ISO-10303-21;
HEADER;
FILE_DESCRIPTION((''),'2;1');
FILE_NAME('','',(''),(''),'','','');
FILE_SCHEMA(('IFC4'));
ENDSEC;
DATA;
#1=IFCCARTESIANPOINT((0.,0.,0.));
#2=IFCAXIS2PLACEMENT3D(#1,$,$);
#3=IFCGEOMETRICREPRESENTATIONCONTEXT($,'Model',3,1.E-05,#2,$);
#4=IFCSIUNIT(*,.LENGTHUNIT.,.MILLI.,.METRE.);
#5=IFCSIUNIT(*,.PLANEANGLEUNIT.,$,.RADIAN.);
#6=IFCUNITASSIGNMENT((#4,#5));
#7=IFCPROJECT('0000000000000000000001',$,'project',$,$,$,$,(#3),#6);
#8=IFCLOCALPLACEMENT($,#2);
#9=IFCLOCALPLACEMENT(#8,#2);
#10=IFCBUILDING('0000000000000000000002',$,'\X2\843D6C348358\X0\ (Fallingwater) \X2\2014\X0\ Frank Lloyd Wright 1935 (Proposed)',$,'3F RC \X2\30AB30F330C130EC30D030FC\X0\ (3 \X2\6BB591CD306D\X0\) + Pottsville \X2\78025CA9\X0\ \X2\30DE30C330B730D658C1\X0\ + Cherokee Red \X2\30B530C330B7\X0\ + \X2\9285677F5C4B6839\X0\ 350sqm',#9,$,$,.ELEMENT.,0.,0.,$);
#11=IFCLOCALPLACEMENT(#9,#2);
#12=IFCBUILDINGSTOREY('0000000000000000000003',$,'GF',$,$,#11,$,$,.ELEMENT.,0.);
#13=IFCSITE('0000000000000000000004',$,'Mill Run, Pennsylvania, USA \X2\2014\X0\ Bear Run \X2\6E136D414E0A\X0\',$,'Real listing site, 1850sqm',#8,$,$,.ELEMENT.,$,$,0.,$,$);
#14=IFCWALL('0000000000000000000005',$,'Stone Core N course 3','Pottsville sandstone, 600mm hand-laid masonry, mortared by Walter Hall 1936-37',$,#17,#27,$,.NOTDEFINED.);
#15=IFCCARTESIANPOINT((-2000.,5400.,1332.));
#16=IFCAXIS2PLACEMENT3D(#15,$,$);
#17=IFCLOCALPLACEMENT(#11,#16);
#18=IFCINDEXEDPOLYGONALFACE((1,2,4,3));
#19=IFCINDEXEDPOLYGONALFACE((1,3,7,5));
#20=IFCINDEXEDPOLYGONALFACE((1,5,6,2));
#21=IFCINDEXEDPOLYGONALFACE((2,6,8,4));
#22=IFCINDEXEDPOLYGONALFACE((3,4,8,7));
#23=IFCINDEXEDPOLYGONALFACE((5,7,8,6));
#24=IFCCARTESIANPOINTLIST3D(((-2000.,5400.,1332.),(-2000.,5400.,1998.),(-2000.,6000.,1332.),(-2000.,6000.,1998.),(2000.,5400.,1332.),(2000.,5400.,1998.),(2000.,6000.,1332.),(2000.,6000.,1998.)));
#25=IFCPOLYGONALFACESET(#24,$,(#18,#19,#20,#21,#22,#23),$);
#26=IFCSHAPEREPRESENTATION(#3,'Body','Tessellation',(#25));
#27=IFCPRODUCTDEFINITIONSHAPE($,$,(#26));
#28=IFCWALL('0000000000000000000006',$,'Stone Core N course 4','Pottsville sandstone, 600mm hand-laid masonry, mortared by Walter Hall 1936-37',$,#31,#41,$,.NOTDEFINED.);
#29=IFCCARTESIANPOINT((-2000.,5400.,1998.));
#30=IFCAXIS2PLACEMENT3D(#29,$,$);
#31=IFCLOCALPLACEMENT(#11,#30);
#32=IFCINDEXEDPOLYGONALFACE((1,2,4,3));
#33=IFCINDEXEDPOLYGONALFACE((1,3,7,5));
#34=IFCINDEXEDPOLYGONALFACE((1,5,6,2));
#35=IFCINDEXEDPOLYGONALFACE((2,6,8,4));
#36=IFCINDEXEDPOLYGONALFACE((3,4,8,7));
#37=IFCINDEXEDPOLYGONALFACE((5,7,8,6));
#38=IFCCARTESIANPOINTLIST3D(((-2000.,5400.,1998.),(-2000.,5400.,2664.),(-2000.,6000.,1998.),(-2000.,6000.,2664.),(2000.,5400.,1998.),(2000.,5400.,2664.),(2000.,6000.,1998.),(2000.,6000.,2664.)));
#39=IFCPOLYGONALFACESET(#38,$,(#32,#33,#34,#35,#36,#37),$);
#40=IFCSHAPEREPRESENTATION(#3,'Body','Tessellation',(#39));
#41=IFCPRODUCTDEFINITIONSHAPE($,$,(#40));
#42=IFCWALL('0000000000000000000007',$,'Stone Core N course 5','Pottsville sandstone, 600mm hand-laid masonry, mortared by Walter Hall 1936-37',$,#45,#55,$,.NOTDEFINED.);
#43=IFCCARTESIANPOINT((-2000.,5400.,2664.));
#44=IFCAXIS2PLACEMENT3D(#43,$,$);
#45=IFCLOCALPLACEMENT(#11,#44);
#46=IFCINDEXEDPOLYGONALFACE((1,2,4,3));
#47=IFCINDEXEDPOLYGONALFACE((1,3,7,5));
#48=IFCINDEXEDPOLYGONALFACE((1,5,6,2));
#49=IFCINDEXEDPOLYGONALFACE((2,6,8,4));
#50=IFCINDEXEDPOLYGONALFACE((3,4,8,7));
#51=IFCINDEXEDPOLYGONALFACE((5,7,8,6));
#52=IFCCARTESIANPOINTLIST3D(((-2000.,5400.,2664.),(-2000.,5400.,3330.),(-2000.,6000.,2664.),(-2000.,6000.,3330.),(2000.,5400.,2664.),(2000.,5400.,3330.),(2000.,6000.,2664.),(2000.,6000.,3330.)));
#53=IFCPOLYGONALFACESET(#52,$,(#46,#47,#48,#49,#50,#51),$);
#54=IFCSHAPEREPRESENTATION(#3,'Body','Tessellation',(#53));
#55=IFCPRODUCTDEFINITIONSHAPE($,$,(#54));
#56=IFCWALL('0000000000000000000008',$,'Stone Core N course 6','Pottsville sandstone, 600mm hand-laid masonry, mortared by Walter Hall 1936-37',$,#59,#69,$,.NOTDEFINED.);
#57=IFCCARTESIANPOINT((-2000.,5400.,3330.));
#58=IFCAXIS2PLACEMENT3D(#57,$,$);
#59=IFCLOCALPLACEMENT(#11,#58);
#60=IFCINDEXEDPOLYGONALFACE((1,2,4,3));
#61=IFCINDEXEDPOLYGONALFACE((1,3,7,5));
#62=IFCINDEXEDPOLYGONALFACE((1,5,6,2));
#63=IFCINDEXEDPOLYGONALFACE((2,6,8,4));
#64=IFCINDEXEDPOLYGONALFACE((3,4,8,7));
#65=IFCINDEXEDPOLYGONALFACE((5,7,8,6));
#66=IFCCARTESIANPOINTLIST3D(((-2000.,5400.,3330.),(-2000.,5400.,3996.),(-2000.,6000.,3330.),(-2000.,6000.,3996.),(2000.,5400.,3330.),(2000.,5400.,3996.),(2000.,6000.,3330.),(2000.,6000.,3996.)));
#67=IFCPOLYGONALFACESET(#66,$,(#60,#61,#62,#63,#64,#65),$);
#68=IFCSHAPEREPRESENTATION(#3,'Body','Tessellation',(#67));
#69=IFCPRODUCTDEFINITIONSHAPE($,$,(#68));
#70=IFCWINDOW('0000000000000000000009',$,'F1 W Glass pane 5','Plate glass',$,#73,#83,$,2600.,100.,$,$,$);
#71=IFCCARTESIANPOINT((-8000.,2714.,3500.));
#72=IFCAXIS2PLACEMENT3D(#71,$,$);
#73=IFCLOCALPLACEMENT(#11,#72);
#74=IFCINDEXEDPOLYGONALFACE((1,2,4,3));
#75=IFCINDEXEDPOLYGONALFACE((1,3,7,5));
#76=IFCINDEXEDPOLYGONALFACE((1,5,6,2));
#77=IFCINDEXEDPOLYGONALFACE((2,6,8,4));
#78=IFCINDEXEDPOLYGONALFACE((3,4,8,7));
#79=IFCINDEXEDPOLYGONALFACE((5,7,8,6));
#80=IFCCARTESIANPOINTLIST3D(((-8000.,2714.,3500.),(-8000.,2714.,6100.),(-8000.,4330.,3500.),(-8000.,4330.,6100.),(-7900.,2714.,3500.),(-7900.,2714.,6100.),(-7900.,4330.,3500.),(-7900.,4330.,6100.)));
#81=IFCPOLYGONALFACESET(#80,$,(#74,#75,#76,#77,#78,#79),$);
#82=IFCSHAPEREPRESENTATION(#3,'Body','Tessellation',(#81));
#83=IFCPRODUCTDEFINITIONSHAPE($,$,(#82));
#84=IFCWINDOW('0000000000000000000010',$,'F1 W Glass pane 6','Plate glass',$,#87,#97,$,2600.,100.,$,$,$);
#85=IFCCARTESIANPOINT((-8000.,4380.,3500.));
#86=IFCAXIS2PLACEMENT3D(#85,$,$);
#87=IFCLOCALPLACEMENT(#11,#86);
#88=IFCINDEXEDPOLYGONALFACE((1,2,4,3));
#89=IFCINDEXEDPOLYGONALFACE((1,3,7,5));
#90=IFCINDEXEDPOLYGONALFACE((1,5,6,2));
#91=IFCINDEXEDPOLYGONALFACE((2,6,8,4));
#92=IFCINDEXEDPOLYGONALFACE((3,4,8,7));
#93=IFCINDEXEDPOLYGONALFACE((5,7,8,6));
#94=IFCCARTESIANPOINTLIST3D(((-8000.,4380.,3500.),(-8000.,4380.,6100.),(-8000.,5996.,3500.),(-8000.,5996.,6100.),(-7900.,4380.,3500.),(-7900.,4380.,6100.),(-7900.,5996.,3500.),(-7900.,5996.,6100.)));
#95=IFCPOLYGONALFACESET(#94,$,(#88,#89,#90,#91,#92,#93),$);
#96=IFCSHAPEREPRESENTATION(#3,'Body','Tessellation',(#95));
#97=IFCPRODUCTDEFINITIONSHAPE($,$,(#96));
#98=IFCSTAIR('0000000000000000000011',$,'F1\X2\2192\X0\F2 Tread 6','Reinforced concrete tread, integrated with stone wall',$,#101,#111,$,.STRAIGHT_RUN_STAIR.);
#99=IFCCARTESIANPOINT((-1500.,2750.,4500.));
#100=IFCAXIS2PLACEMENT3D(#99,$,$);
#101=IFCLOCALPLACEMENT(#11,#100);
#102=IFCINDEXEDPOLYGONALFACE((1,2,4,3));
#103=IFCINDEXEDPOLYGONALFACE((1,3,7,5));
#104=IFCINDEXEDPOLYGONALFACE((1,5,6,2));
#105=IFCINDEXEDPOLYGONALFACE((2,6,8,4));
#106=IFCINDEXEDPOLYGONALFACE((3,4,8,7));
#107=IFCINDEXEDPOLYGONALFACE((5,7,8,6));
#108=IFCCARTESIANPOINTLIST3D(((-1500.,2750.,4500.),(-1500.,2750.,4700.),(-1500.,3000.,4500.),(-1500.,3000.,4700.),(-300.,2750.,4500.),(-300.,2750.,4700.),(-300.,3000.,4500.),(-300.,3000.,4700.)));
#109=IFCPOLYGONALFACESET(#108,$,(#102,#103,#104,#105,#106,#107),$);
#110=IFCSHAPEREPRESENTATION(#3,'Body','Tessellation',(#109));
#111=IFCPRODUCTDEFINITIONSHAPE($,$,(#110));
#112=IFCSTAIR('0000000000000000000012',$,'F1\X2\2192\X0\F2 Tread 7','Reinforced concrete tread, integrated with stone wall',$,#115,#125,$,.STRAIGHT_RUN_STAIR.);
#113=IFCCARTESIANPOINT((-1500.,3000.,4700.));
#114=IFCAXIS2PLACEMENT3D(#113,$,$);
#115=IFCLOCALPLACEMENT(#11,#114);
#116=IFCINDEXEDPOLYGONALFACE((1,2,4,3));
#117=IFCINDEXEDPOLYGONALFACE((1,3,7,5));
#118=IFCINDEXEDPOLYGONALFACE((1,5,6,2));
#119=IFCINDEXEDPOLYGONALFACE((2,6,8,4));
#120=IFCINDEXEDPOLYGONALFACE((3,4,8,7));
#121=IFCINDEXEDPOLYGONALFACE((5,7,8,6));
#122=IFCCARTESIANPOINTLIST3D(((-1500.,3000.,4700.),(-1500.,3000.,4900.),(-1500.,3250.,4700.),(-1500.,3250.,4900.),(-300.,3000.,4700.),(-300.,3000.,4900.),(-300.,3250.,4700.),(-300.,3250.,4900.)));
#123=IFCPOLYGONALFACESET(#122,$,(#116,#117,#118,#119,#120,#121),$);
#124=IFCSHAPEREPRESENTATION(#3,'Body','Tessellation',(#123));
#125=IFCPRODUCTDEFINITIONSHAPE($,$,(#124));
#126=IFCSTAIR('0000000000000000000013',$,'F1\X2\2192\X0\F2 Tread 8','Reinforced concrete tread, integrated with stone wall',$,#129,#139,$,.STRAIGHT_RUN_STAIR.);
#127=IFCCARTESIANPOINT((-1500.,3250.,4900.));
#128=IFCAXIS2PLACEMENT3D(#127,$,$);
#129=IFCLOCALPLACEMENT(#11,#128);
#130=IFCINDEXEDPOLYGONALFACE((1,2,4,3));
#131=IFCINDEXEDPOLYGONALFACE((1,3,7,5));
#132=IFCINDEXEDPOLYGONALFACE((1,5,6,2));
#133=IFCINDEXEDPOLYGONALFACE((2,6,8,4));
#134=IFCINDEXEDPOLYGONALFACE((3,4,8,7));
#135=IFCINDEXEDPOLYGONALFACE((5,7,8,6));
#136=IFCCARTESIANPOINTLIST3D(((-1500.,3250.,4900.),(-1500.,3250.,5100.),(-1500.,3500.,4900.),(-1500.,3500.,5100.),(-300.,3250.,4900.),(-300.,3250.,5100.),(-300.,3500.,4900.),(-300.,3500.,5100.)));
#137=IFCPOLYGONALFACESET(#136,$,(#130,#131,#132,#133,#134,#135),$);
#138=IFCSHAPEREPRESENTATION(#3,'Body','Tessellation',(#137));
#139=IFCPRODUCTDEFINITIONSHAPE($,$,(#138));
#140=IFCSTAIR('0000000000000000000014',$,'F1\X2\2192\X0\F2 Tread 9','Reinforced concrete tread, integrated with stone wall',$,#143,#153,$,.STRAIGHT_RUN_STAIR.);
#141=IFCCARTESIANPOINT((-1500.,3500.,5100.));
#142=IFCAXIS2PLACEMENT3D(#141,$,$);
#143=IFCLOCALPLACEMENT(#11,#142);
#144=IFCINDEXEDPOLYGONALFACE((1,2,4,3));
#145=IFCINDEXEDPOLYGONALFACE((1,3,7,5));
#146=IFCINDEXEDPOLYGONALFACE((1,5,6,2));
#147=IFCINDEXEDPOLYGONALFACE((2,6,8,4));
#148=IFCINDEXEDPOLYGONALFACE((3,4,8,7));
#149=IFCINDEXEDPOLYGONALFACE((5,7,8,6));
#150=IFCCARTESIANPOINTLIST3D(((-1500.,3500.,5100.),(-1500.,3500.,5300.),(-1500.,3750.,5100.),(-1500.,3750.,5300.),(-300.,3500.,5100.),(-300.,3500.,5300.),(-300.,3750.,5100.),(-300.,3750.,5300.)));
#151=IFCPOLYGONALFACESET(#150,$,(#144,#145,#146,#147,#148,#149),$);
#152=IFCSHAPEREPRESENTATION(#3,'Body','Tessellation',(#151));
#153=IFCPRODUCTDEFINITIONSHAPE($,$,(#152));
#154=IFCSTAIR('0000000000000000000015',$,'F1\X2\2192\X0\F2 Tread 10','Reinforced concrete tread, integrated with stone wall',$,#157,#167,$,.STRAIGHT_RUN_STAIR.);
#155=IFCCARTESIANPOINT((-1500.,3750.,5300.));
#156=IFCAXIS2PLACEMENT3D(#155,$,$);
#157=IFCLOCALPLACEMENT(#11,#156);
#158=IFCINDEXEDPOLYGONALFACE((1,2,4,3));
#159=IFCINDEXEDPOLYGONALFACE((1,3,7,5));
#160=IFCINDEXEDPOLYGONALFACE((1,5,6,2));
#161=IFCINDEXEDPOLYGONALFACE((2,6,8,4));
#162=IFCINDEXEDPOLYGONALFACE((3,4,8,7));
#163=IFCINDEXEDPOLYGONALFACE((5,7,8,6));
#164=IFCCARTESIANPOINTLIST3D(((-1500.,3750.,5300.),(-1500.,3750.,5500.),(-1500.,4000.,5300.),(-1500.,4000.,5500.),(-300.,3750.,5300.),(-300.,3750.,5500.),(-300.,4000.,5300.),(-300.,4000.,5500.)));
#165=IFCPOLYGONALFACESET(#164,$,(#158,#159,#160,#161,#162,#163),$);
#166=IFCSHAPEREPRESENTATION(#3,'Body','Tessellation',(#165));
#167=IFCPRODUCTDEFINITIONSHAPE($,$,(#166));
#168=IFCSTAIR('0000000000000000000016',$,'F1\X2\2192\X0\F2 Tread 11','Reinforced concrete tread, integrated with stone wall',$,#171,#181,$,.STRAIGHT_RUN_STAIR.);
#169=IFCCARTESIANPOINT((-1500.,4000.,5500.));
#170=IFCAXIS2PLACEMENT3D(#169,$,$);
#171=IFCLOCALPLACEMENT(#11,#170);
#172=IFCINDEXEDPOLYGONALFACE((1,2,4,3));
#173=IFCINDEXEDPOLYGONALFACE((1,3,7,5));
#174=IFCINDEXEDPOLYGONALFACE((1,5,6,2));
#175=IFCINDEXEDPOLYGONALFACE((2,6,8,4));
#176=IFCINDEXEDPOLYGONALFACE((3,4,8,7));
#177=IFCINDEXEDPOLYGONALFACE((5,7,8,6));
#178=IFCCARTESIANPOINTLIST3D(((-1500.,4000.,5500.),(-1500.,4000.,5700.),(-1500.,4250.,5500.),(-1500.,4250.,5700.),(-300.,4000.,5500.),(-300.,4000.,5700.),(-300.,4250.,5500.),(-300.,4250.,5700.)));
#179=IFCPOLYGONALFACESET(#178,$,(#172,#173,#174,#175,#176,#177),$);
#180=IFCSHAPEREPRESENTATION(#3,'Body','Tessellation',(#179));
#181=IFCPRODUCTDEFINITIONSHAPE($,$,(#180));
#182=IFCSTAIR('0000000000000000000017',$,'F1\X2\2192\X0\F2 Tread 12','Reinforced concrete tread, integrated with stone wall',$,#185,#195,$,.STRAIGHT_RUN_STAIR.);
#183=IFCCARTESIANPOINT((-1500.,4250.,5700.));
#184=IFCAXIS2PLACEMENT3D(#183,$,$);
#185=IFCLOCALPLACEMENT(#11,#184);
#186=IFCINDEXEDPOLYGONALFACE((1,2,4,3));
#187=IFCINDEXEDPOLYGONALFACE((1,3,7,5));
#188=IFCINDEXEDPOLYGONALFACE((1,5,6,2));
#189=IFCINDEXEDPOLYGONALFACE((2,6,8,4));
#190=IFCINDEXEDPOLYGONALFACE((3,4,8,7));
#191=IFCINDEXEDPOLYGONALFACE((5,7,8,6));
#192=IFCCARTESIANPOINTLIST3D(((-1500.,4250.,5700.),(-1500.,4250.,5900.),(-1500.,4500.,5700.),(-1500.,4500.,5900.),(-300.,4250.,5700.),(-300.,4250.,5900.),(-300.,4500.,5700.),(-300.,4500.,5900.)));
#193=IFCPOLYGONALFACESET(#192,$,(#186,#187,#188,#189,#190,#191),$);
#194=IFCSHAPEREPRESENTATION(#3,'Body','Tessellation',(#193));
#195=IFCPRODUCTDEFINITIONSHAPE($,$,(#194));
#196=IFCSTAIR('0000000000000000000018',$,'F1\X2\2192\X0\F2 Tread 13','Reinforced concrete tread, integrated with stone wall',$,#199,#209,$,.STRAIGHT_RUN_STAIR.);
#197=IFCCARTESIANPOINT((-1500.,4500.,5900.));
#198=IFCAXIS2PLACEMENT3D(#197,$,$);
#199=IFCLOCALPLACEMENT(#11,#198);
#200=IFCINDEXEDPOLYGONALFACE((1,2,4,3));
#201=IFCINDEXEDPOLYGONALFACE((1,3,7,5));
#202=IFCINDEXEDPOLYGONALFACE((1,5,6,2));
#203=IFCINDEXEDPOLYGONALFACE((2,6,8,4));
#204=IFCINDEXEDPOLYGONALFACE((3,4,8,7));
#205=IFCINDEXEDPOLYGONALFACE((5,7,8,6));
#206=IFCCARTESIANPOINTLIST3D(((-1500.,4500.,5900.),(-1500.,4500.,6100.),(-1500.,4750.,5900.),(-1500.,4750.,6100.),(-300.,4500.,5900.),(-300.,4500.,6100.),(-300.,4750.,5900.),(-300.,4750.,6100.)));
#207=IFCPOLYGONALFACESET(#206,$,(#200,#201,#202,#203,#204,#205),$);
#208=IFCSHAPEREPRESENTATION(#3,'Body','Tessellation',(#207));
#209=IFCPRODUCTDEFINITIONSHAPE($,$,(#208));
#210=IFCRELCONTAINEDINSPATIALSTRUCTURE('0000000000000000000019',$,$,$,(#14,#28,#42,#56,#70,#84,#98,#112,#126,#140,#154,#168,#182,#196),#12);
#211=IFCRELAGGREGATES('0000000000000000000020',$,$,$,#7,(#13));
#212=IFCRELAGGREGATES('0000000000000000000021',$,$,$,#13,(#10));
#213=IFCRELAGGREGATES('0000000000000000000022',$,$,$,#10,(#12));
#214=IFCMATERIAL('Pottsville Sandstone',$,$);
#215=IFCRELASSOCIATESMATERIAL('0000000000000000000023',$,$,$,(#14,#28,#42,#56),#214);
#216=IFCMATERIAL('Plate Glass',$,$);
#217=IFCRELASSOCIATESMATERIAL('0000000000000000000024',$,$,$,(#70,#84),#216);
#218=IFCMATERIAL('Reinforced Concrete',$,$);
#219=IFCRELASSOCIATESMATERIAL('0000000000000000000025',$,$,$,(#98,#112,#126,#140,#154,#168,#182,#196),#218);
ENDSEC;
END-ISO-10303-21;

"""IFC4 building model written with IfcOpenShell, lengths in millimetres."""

from ifc_helpers import new_model, si_unit, frame, frame_2d, origin, place, context, project, spatial, rectangle, extrude, material, element, save


model = new_model("IFC4")

# Units and contexts
model_context = context("Model", 3, precision=1e-05, world=origin())
ifc_project = project(units=[si_unit("LENGTHUNIT", "METRE", prefix="MILLI"), si_unit("PLANEANGLEUNIT", "RADIAN")], contexts=[model_context])

# Site, building, storey
site_placement = place(None, origin())
site = spatial("IfcSite", under=ifc_project, at=site_placement, Name="Mill Run, Pennsylvania, USA — Bear Run 渓流上", ObjectType="Real listing site, 1850sqm", CompositionType="ELEMENT", RefElevation=0.0)
building_placement = place(site_placement, origin())
building = spatial("IfcBuilding", under=site, at=building_placement, Name="落水荘 (Fallingwater) — Frank Lloyd Wright 1935 (Proposed)", ObjectType="3F RC カンチレバー (3 段重ね) + Pottsville 砂岩 マッシブ壁 + Cherokee Red サッシ + 銅板屋根 350sqm", CompositionType="ELEMENT", ElevationOfRefHeight=0.0, ElevationOfTerrain=0.0)
storey_placement = place(building_placement, origin())
storey = spatial("IfcBuildingStorey", under=building, at=storey_placement, Name="GF", CompositionType="ELEMENT", Elevation=0.0)

# Walls
ifc_material_1 = material(Name="Pottsville Sandstone")
wall_1_placement = place(storey_placement, frame((-2000.0, 5400.0, 1332.0)))
element("IfcWall", 1, at=wall_1_placement, inside=storey, material=ifc_material_1, Name="Stone Core N course 3", Description="Pottsville sandstone, 600mm hand-laid masonry, mortared by Walter Hall 1936-37", PredefinedType="NOTDEFINED", context=model_context, shape_type="SweptSolid", body=[
    extrude(rectangle(XDim=4000.0, YDim=600.0, at=frame_2d((2000.0, 300.0))), frame((-2000.0, 5400.0, 1332.0)), (0.0, 0.0, 1.0), 666.0),
])
wall_2_placement = place(storey_placement, frame((-2000.0, 5400.0, 1998.0)))
element("IfcWall", 2, at=wall_2_placement, inside=storey, material=ifc_material_1, Name="Stone Core N course 4", Description="Pottsville sandstone, 600mm hand-laid masonry, mortared by Walter Hall 1936-37", PredefinedType="NOTDEFINED", context=model_context, shape_type="SweptSolid", body=[
    extrude(rectangle(XDim=4000.0, YDim=600.0, at=frame_2d((2000.0, 300.0))), frame((-2000.0, 5400.0, 1998.0)), (0.0, 0.0, 1.0), 666.0),
])
wall_3_placement = place(storey_placement, frame((-2000.0, 5400.0, 2664.0)))
element("IfcWall", 3, at=wall_3_placement, inside=storey, material=ifc_material_1, Name="Stone Core N course 5", Description="Pottsville sandstone, 600mm hand-laid masonry, mortared by Walter Hall 1936-37", PredefinedType="NOTDEFINED", context=model_context, shape_type="SweptSolid", body=[
    extrude(rectangle(XDim=4000.0, YDim=600.0, at=frame_2d((2000.0, 300.0))), frame((-2000.0, 5400.0, 2664.0)), (0.0, 0.0, 1.0), 666.0),
])
wall_4_placement = place(storey_placement, frame((-2000.0, 5400.0, 3330.0)))
element("IfcWall", 4, at=wall_4_placement, inside=storey, material=ifc_material_1, Name="Stone Core N course 6", Description="Pottsville sandstone, 600mm hand-laid masonry, mortared by Walter Hall 1936-37", PredefinedType="NOTDEFINED", context=model_context, shape_type="SweptSolid", body=[
    extrude(rectangle(XDim=4000.0, YDim=600.0, at=frame_2d((2000.0, 300.0))), frame((-2000.0, 5400.0, 3330.0)), (0.0, 0.0, 1.0), 666.0),
])

# Windows
ifc_material_2 = material(Name="Plate Glass")
window_1_placement = place(storey_placement, frame((-8000.0, 2714.0, 3500.0)))
element("IfcWindow", 5, at=window_1_placement, inside=storey, material=ifc_material_2, Name="F1 W Glass pane 5", Description="Plate glass", OverallHeight=2600.0, OverallWidth=100.0, context=model_context, shape_type="SweptSolid", body=[
    extrude(rectangle(XDim=100.0, YDim=1616.0, at=frame_2d((50.0, 808.0))), frame((-8000.0, 2714.0, 3500.0)), (0.0, 0.0, 1.0), 2600.0),
])
window_2_placement = place(storey_placement, frame((-8000.0, 4380.0, 3500.0)))
element("IfcWindow", 6, at=window_2_placement, inside=storey, material=ifc_material_2, Name="F1 W Glass pane 6", Description="Plate glass", OverallHeight=2600.0, OverallWidth=100.0, context=model_context, shape_type="SweptSolid", body=[
    extrude(rectangle(XDim=100.0, YDim=1616.0, at=frame_2d((50.0, 808.0))), frame((-8000.0, 4380.0, 3500.0)), (0.0, 0.0, 1.0), 2600.0),
])

# Stairs
ifc_material_3 = material(Name="Reinforced Concrete")
stair_1_placement = place(storey_placement, frame((-1500.0, 2750.0, 4500.0)))
element("IfcStair", 7, at=stair_1_placement, inside=storey, material=ifc_material_3, Name="F1→F2 Tread 6", Description="Reinforced concrete tread, integrated with stone wall", PredefinedType="STRAIGHT_RUN_STAIR", context=model_context, shape_type="SweptSolid", body=[
    extrude(rectangle(XDim=1200.0, YDim=250.0, at=frame_2d((600.0, 125.0))), frame((-1500.0, 2750.0, 4500.0)), (0.0, 0.0, 1.0), 200.0),
])
stair_2_placement = place(storey_placement, frame((-1500.0, 3000.0, 4700.0)))
element("IfcStair", 8, at=stair_2_placement, inside=storey, material=ifc_material_3, Name="F1→F2 Tread 7", Description="Reinforced concrete tread, integrated with stone wall", PredefinedType="STRAIGHT_RUN_STAIR", context=model_context, shape_type="SweptSolid", body=[
    extrude(rectangle(XDim=1200.0, YDim=250.0, at=frame_2d((600.0, 125.0))), frame((-1500.0, 3000.0, 4700.0)), (0.0, 0.0, 1.0), 200.0),
])
stair_3_placement = place(storey_placement, frame((-1500.0, 3250.0, 4900.0)))
element("IfcStair", 9, at=stair_3_placement, inside=storey, material=ifc_material_3, Name="F1→F2 Tread 8", Description="Reinforced concrete tread, integrated with stone wall", PredefinedType="STRAIGHT_RUN_STAIR", context=model_context, shape_type="SweptSolid", body=[
    extrude(rectangle(XDim=1200.0, YDim=250.0, at=frame_2d((600.0, 125.0))), frame((-1500.0, 3250.0, 4900.0)), (0.0, 0.0, 1.0), 200.0),
])
stair_4_placement = place(storey_placement, frame((-1500.0, 3500.0, 5100.0)))
element("IfcStair", 10, at=stair_4_placement, inside=storey, material=ifc_material_3, Name="F1→F2 Tread 9", Description="Reinforced concrete tread, integrated with stone wall", PredefinedType="STRAIGHT_RUN_STAIR", context=model_context, shape_type="SweptSolid", body=[
    extrude(rectangle(XDim=1200.0, YDim=250.0, at=frame_2d((600.0, 125.0))), frame((-1500.0, 3500.0, 5100.0)), (0.0, 0.0, 1.0), 200.0),
])
stair_5_placement = place(storey_placement, frame((-1500.0, 3750.0, 5300.0)))
element("IfcStair", 11, at=stair_5_placement, inside=storey, material=ifc_material_3, Name="F1→F2 Tread 10", Description="Reinforced concrete tread, integrated with stone wall", PredefinedType="STRAIGHT_RUN_STAIR", context=model_context, shape_type="SweptSolid", body=[
    extrude(rectangle(XDim=1200.0, YDim=250.0, at=frame_2d((600.0, 125.0))), frame((-1500.0, 3750.0, 5300.0)), (0.0, 0.0, 1.0), 200.0),
])
stair_6_placement = place(storey_placement, frame((-1500.0, 4000.0, 5500.0)))
element("IfcStair", 12, at=stair_6_placement, inside=storey, material=ifc_material_3, Name="F1→F2 Tread 11", Description="Reinforced concrete tread, integrated with stone wall", PredefinedType="STRAIGHT_RUN_STAIR", context=model_context, shape_type="SweptSolid", body=[
    extrude(rectangle(XDim=1200.0, YDim=250.0, at=frame_2d((600.0, 125.0))), frame((-1500.0, 4000.0, 5500.0)), (0.0, 0.0, 1.0), 200.0),
])
stair_7_placement = place(storey_placement, frame((-1500.0, 4250.0, 5700.0)))
element("IfcStair", 13, at=stair_7_placement, inside=storey, material=ifc_material_3, Name="F1→F2 Tread 12", Description="Reinforced concrete tread, integrated with stone wall", PredefinedType="STRAIGHT_RUN_STAIR", context=model_context, shape_type="SweptSolid", body=[
    extrude(rectangle(XDim=1200.0, YDim=250.0, at=frame_2d((600.0, 125.0))), frame((-1500.0, 4250.0, 5700.0)), (0.0, 0.0, 1.0), 200.0),
])
stair_8_placement = place(storey_placement, frame((-1500.0, 4500.0, 5900.0)))
element("IfcStair", 14, at=stair_8_placement, inside=storey, material=ifc_material_3, Name="F1→F2 Tread 13", Description="Reinforced concrete tread, integrated with stone wall", PredefinedType="STRAIGHT_RUN_STAIR", context=model_context, shape_type="SweptSolid", body=[
    extrude(rectangle(XDim=1200.0, YDim=250.0, at=frame_2d((600.0, 125.0))), frame((-1500.0, 4500.0, 5900.0)), (0.0, 0.0, 1.0), 200.0),
])

save(model, "model.ifc")
